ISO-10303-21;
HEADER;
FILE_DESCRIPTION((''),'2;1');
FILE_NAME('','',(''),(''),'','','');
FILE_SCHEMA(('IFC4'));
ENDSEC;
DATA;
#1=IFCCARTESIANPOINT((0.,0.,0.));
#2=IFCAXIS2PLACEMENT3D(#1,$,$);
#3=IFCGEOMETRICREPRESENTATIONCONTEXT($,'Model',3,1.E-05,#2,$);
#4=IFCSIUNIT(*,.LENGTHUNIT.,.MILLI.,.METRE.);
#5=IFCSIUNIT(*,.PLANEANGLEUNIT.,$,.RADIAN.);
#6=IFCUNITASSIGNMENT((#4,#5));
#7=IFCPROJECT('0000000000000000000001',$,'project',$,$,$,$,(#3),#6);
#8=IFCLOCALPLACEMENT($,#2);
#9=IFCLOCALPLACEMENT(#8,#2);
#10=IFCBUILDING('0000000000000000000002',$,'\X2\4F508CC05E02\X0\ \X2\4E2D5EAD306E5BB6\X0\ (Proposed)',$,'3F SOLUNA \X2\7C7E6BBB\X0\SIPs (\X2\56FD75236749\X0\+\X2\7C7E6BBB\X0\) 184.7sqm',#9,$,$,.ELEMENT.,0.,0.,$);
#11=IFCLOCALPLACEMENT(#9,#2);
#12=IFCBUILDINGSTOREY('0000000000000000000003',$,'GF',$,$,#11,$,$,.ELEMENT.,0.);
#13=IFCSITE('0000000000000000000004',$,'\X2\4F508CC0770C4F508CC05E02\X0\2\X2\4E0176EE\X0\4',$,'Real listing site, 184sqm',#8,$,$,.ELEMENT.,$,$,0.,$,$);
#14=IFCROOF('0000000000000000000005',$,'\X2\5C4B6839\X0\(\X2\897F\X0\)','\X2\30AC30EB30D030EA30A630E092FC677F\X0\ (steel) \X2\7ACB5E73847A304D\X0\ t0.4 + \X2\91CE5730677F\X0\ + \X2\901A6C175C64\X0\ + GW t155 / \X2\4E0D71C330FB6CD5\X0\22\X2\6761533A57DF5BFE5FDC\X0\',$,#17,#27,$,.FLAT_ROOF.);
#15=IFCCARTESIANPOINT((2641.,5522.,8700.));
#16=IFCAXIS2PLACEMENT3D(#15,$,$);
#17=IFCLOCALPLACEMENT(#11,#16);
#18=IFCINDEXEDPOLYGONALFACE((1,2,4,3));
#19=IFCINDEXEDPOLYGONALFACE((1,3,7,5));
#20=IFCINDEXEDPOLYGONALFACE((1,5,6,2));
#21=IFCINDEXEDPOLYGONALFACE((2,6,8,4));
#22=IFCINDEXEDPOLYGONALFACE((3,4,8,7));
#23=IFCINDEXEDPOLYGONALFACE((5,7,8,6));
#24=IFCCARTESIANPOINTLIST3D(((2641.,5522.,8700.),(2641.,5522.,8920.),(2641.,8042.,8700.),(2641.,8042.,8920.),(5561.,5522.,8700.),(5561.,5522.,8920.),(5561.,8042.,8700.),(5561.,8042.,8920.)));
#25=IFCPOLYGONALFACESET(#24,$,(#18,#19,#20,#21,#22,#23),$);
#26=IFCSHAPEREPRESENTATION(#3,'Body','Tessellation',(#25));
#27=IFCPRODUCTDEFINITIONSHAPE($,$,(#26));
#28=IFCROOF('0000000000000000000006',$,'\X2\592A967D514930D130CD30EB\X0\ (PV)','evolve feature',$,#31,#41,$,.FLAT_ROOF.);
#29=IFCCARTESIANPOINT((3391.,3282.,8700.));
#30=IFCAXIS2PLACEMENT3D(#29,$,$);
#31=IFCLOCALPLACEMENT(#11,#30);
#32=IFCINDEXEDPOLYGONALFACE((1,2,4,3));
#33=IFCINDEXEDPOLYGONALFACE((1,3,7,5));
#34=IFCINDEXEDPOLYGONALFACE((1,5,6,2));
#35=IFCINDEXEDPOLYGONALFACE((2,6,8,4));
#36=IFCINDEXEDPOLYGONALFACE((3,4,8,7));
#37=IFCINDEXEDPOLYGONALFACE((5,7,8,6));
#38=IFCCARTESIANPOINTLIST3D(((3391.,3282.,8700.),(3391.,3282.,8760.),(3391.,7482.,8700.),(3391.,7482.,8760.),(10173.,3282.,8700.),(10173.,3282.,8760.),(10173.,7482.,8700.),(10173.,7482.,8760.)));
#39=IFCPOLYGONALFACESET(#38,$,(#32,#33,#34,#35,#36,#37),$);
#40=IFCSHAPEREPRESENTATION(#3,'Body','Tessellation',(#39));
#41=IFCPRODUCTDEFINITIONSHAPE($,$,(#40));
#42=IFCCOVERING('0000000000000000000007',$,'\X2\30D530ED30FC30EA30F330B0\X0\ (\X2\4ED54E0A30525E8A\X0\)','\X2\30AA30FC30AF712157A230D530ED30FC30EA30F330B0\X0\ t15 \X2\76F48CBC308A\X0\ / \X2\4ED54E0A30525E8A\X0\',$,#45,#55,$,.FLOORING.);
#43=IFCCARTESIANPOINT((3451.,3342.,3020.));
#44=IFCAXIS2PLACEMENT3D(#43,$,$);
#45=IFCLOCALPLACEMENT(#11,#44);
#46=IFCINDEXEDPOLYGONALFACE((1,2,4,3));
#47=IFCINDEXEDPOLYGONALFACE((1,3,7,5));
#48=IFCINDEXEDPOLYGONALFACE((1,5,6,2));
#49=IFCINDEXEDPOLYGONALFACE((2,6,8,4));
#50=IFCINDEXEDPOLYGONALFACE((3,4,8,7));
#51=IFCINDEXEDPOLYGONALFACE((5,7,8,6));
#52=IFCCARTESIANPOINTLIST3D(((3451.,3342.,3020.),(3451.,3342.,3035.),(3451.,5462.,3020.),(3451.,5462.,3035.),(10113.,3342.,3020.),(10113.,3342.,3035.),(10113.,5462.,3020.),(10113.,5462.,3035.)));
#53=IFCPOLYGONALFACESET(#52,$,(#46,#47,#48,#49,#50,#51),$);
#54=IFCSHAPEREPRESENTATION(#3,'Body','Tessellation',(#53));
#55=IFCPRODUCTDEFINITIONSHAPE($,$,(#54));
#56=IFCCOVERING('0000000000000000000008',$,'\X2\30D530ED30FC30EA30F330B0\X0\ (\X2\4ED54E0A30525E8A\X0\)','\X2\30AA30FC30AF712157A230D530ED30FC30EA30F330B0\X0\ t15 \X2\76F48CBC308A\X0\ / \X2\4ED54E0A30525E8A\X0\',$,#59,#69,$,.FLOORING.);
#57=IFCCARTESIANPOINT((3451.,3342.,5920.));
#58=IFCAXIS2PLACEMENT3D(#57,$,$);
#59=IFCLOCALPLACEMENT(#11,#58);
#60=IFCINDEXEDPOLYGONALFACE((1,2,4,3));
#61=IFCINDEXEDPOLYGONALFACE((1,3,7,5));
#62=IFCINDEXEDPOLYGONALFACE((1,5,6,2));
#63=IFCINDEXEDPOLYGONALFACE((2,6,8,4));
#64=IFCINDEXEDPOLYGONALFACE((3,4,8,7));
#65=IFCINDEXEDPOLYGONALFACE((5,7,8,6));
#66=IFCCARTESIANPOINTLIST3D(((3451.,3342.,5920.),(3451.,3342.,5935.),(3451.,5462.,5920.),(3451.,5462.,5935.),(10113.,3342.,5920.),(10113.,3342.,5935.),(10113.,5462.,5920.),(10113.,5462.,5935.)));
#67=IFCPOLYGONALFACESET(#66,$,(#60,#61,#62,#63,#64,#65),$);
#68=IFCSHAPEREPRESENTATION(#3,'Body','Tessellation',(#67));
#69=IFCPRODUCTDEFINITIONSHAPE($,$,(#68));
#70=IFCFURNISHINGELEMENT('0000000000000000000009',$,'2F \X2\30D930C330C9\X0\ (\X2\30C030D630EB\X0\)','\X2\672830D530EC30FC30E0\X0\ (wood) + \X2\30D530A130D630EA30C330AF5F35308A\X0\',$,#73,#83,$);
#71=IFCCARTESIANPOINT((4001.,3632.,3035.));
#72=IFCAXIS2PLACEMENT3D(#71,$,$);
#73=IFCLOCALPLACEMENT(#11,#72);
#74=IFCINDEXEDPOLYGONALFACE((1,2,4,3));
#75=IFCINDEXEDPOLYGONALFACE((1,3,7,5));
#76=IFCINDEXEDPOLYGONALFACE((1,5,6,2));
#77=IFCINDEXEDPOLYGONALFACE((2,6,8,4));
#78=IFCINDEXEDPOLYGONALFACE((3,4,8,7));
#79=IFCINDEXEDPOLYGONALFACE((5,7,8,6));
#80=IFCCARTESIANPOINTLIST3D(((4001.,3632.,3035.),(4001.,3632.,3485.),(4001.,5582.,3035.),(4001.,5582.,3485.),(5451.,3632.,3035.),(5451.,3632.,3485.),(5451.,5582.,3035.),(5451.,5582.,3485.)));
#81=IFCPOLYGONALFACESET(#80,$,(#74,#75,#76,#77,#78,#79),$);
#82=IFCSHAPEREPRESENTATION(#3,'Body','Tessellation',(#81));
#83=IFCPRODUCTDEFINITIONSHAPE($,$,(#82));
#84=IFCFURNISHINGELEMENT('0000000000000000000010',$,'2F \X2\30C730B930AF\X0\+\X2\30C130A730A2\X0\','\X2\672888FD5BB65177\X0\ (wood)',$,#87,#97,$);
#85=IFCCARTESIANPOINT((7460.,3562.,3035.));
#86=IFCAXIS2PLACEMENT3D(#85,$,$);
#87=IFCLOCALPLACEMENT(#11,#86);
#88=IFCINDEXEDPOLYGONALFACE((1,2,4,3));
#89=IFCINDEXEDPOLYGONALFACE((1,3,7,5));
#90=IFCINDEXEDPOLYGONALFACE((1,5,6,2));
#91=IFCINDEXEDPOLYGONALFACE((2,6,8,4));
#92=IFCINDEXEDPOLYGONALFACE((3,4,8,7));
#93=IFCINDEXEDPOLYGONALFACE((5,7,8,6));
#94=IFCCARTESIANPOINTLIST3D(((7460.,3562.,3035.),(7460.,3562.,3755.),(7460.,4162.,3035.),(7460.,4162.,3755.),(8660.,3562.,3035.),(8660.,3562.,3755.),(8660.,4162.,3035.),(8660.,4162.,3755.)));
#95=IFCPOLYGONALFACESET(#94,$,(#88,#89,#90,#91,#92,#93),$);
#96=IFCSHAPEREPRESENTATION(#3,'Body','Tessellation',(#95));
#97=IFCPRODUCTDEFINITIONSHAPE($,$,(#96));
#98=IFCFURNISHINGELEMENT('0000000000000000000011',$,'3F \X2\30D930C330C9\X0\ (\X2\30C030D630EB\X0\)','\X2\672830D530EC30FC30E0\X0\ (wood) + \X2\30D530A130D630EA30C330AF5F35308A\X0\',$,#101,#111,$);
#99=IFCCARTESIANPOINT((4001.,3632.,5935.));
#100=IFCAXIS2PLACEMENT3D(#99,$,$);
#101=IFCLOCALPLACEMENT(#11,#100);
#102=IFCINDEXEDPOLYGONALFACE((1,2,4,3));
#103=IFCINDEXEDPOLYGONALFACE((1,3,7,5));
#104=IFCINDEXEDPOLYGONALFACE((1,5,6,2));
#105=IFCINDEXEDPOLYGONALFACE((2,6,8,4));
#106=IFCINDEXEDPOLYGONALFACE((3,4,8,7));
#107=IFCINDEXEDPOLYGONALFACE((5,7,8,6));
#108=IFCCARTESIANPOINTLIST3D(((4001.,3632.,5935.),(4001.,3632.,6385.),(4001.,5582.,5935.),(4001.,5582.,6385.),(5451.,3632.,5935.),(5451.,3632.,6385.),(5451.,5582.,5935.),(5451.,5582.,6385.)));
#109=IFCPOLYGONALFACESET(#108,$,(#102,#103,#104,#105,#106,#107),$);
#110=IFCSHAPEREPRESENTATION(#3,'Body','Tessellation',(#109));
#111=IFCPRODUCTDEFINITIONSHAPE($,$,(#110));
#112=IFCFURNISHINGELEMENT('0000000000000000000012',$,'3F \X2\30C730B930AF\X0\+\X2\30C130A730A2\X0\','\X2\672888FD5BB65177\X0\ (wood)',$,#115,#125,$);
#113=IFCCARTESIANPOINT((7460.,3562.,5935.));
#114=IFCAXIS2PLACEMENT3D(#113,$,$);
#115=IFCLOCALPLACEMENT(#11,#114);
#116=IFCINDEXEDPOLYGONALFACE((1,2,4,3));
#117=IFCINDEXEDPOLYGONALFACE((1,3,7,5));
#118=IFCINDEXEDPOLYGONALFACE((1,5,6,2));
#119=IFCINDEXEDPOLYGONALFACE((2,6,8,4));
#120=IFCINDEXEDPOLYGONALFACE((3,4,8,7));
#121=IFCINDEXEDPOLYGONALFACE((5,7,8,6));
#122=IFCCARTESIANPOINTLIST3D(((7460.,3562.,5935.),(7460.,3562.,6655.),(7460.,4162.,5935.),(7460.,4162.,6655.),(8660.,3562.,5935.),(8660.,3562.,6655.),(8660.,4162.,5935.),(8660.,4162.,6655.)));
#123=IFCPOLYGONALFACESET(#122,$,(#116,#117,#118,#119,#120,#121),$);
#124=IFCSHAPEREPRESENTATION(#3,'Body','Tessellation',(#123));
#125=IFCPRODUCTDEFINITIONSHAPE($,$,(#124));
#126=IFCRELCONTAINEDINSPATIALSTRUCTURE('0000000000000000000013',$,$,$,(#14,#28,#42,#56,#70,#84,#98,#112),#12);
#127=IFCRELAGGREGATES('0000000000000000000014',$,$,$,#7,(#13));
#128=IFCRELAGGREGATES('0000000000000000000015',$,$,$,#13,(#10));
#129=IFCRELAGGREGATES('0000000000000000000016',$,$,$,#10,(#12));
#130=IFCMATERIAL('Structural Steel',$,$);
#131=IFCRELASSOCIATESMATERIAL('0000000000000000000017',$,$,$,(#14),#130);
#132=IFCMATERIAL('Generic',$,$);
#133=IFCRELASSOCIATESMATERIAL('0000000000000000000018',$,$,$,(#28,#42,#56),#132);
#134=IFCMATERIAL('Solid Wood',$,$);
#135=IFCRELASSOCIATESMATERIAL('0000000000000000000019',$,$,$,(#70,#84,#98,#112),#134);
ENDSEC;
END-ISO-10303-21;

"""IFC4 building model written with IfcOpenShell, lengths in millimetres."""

from ifc_helpers import new_model, si_unit, frame, frame_2d, origin, place, context, project, spatial, rectangle, extrude, material, element, save


model = new_model("IFC4")

# Units and contexts
model_context = context("Model", 3, precision=1e-05, world=origin())
ifc_project = project(units=[si_unit("LENGTHUNIT", "METRE", prefix="MILLI"), si_unit("PLANEANGLEUNIT", "RADIAN")], contexts=[model_context])

# Site, building, storey
site_placement = place(None, origin())
site = spatial("IfcSite", under=ifc_project, at=site_placement, Name="佐賀県佐賀市2丁目4", ObjectType="Real listing site, 184sqm", CompositionType="ELEMENT", RefElevation=0.0)
building_placement = place(site_placement, origin())
building = spatial("IfcBuilding", under=site, at=building_placement, Name="佐賀市 中庭の家 (Proposed)", ObjectType="3F SOLUNA 籾殻SIPs (国産杉+籾殻) 184.7sqm", CompositionType="ELEMENT", ElevationOfRefHeight=0.0, ElevationOfTerrain=0.0)
storey_placement = place(building_placement, origin())
storey = spatial("IfcBuildingStorey", under=building, at=storey_placement, Name="GF", CompositionType="ELEMENT", Elevation=0.0)

# Shared definitions
ifc_material_1 = material(Name="Solid Wood")

# Roofs
ifc_material_2 = material(Name="Structural Steel")
roof_1_placement = place(storey_placement, frame((2641.0, 5522.0, 8700.0)))
element("IfcRoof", 1, at=roof_1_placement, inside=storey, material=ifc_material_2, Name="屋根(西)", Description="ガルバリウム鋼板 (steel) 立平葺き t0.4 + 野地板 + 通気層 + GW t155 / 不燃・法22条区域対応", PredefinedType="FLAT_ROOF", context=model_context, shape_type="SweptSolid", body=[
    extrude(rectangle(XDim=2920.0, YDim=2520.0, at=frame_2d((1460.0, 1260.0))), frame((2641.0, 5522.0, 8700.0)), (0.0, 0.0, 1.0), 220.0),
])
ifc_material_3 = material(Name="Generic")
roof_2_placement = place(storey_placement, frame((3391.0, 3282.0, 8700.0)))
element("IfcRoof", 2, at=roof_2_placement, inside=storey, material=ifc_material_3, Name="太陽光パネル (PV)", Description="evolve feature", PredefinedType="FLAT_ROOF", context=model_context, shape_type="SweptSolid", body=[
    extrude(rectangle(XDim=6782.0, YDim=4200.0, at=frame_2d((3391.0, 2100.0))), frame((3391.0, 3282.0, 8700.0)), (0.0, 0.0, 1.0), 60.0),
])

# Coverings
covering_1_placement = place(storey_placement, frame((3451.0, 3342.0, 3020.0)))
element("IfcCovering", 3, at=covering_1_placement, inside=storey, material=ifc_material_3, Name="フローリング (仕上げ床)", Description="オーク無垢フローリング t15 直貼り / 仕上げ床", PredefinedType="FLOORING", context=model_context, shape_type="SweptSolid", body=[
    extrude(rectangle(XDim=6662.0, YDim=2120.0, at=frame_2d((3331.0, 1060.0))), frame((3451.0, 3342.0, 3020.0)), (0.0, 0.0, 1.0), 15.0),
])
covering_2_placement = place(storey_placement, frame((3451.0, 3342.0, 5920.0)))
element("IfcCovering", 4, at=covering_2_placement, inside=storey, material=ifc_material_3, Name="フローリング (仕上げ床)", Description="オーク無垢フローリング t15 直貼り / 仕上げ床", PredefinedType="FLOORING", context=model_context, shape_type="SweptSolid", body=[
    extrude(rectangle(XDim=6662.0, YDim=2120.0, at=frame_2d((3331.0, 1060.0))), frame((3451.0, 3342.0, 5920.0)), (0.0, 0.0, 1.0), 15.0),
])

# Furnishing elements
furnishing_1_placement = place(storey_placement, frame((4001.0, 3632.0, 3035.0)))
element("IfcFurnishingElement", 5, at=furnishing_1_placement, inside=storey, material=ifc_material_1, Name="2F ベッド (ダブル)", Description="木フレーム (wood) + ファブリック張り", context=model_context, shape_type="SweptSolid", body=[
    extrude(rectangle(XDim=1450.0, YDim=1950.0, at=frame_2d((725.0, 975.0))), frame((4001.0, 3632.0, 3035.0)), (0.0, 0.0, 1.0), 450.0),
])
furnishing_2_placement = place(storey_placement, frame((7460.0, 3562.0, 3035.0)))
element("IfcFurnishingElement", 6, at=furnishing_2_placement, inside=storey, material=ifc_material_1, Name="2F デスク+チェア", Description="木製家具 (wood)", context=model_context, shape_type="SweptSolid", body=[
    extrude(rectangle(XDim=1200.0, YDim=600.0, at=frame_2d((600.0, 300.0))), frame((7460.0, 3562.0, 3035.0)), (0.0, 0.0, 1.0), 720.0),
])
furnishing_3_placement = place(storey_placement, frame((4001.0, 3632.0, 5935.0)))
element("IfcFurnishingElement", 7, at=furnishing_3_placement, inside=storey, material=ifc_material_1, Name="3F ベッド (ダブル)", Description="木フレーム (wood) + ファブリック張り", context=model_context, shape_type="SweptSolid", body=[
    extrude(rectangle(XDim=1450.0, YDim=1950.0, at=frame_2d((725.0, 975.0))), frame((4001.0, 3632.0, 5935.0)), (0.0, 0.0, 1.0), 450.0),
])
furnishing_4_placement = place(storey_placement, frame((7460.0, 3562.0, 5935.0)))
element("IfcFurnishingElement", 8, at=furnishing_4_placement, inside=storey, material=ifc_material_1, Name="3F デスク+チェア", Description="木製家具 (wood)", context=model_context, shape_type="SweptSolid", body=[
    extrude(rectangle(XDim=1200.0, YDim=600.0, at=frame_2d((600.0, 300.0))), frame((7460.0, 3562.0, 5935.0)), (0.0, 0.0, 1.0), 720.0),
])

save(model, "model.ifc")
